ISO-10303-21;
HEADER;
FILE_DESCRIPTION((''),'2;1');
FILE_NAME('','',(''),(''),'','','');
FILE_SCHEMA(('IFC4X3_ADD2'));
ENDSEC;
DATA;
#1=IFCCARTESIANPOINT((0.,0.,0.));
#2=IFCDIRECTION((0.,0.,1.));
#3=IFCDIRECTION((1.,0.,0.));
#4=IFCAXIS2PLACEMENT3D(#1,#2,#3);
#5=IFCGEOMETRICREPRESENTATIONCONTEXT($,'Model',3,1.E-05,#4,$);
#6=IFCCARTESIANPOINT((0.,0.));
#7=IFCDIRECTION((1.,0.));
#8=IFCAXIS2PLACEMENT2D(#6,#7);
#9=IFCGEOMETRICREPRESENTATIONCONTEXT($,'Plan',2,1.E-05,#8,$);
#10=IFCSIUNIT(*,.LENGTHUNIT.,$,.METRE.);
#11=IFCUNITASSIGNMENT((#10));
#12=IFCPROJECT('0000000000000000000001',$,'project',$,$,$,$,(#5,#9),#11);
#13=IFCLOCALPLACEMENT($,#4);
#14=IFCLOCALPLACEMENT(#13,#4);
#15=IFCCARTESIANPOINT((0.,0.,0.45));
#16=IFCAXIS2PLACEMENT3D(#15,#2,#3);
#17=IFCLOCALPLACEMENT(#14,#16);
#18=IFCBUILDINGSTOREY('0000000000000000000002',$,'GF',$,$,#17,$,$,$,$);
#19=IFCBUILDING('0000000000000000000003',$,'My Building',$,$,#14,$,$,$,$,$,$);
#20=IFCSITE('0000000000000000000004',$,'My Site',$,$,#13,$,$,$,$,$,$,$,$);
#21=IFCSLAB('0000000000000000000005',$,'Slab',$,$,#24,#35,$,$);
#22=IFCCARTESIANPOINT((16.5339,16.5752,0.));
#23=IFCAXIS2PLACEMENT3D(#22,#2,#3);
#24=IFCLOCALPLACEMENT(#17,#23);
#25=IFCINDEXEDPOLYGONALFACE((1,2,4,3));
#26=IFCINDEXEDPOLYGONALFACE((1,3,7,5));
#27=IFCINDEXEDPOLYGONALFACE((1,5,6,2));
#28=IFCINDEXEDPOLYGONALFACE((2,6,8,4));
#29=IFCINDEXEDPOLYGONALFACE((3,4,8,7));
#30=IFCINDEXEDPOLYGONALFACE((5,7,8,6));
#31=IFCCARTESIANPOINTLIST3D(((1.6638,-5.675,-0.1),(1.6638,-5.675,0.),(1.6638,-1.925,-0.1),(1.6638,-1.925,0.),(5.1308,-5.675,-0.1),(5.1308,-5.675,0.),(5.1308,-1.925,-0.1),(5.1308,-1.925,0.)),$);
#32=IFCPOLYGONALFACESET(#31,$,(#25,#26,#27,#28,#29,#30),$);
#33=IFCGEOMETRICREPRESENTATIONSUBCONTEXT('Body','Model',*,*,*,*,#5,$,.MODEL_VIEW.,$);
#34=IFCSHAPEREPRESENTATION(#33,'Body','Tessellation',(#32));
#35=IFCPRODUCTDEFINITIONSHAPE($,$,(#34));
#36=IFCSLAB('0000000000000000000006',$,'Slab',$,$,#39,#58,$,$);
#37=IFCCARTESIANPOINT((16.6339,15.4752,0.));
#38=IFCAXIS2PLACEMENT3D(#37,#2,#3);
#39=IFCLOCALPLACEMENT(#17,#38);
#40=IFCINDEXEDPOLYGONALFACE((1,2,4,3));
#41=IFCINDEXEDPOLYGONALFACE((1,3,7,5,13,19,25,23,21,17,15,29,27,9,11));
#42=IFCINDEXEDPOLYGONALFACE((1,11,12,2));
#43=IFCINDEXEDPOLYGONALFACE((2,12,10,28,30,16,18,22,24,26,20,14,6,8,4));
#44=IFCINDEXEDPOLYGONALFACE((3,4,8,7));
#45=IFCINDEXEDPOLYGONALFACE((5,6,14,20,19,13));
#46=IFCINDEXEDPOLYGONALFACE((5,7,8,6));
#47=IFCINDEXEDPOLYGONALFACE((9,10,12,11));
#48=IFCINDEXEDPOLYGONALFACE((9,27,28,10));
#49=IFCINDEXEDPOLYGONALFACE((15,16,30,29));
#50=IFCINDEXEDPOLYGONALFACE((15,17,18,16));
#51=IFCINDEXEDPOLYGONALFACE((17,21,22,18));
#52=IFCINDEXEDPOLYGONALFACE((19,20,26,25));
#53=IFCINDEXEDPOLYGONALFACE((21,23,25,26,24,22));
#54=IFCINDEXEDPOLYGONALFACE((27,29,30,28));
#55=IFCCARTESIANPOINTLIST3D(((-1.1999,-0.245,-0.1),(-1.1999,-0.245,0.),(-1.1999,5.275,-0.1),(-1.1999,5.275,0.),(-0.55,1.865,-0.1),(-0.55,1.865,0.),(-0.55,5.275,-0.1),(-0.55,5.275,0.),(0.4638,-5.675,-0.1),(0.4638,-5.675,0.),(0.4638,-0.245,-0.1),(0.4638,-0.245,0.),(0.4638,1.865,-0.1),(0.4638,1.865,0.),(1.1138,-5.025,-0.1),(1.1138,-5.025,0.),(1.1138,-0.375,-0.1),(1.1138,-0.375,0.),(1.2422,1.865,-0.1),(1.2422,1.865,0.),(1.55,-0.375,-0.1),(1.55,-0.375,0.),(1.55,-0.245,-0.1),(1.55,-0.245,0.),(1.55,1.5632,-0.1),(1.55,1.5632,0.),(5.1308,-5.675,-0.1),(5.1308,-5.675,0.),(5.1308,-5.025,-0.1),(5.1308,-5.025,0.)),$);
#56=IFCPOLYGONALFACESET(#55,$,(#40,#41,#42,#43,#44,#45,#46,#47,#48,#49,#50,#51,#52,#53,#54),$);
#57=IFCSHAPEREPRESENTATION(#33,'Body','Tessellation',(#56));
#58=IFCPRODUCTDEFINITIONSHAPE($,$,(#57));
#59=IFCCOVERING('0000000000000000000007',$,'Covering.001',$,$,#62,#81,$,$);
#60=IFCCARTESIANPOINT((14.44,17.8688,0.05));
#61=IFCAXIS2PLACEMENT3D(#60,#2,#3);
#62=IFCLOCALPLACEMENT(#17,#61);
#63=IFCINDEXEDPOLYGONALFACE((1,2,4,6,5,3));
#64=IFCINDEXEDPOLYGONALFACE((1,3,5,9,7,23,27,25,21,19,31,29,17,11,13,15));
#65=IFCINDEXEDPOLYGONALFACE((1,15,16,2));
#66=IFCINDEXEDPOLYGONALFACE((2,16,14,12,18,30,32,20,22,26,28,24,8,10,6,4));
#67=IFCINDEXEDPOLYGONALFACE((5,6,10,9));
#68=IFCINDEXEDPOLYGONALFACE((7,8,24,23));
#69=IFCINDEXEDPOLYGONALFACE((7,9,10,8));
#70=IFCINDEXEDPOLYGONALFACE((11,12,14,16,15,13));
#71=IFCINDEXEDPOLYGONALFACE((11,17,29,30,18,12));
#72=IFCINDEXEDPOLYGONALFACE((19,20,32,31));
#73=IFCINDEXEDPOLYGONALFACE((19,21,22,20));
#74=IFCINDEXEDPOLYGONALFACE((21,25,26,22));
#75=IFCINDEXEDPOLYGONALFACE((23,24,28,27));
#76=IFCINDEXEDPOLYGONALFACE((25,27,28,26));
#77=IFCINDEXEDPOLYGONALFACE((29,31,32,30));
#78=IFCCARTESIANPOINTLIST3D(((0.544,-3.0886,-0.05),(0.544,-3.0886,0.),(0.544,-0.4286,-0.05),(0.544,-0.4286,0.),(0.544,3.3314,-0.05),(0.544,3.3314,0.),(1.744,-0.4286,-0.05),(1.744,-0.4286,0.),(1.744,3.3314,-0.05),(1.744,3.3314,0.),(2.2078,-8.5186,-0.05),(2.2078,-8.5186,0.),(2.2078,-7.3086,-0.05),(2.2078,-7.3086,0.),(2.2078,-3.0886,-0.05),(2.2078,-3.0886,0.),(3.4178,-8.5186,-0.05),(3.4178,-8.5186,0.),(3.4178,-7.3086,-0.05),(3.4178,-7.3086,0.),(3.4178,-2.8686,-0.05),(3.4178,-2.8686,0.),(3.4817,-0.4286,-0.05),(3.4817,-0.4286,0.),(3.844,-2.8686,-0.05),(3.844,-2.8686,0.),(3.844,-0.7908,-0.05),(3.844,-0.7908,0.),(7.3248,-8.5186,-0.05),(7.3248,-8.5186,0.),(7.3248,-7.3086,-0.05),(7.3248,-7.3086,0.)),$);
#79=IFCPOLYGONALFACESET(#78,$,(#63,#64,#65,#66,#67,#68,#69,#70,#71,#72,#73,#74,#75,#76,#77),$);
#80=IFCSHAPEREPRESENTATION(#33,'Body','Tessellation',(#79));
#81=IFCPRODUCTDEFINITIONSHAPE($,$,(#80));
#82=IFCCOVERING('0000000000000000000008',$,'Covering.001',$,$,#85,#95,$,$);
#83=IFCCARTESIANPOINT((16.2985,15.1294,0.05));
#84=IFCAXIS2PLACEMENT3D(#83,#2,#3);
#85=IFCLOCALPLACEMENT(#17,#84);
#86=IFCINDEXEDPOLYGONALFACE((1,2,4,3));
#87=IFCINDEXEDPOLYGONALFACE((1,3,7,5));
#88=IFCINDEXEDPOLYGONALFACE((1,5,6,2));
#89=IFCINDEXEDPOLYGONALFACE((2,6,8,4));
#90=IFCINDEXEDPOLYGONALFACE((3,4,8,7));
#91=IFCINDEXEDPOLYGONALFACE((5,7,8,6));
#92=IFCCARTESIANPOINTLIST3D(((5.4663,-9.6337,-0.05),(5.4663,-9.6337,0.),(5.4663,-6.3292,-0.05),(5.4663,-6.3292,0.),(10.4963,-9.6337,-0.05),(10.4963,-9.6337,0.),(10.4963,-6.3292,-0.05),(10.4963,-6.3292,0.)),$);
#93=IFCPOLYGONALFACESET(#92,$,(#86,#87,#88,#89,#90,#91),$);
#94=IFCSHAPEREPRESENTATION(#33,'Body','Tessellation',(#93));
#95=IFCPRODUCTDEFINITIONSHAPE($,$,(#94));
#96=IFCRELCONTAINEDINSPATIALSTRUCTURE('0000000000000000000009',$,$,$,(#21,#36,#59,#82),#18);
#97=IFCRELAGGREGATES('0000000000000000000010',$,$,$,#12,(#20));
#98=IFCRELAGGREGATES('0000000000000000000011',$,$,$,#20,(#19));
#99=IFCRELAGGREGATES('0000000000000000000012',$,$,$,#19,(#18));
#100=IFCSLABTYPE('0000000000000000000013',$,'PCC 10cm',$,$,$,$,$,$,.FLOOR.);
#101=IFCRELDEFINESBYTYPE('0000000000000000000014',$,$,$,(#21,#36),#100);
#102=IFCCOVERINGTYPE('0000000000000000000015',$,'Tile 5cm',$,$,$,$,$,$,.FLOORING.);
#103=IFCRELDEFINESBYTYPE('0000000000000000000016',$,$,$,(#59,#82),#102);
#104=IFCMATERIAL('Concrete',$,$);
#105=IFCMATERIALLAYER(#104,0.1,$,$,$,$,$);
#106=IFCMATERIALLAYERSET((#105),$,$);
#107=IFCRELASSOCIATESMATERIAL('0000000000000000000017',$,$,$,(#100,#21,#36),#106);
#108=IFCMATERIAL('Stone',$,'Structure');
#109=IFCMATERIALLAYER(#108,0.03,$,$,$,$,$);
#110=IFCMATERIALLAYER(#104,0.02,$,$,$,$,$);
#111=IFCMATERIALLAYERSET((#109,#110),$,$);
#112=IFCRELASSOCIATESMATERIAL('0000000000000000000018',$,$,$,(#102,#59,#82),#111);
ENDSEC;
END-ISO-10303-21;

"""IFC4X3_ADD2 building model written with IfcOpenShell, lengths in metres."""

from ifc_helpers import new_model, si_unit, frame, origin_with_axes, origin_2d_with_axis, place, context, subcontext, project, spatial, indexed_curve, outline, extrude, material, layer, layer_set, layer_usage, type_object, element, save


model = new_model("IFC4X3_ADD2")

# Units and contexts
model_context = context("Model", 3, precision=1e-05, world=origin_with_axes())
plan_context = context("Plan", 2, precision=1e-05, world=origin_2d_with_axis())
body_context_1 = subcontext(model_context, "Body", "Model", "MODEL_VIEW")
ifc_project = project(units=[si_unit("LENGTHUNIT", "METRE")], contexts=[model_context, plan_context])

# Site, building, storey
site_placement = place(None, origin_with_axes())
site = spatial("IfcSite", under=ifc_project, at=site_placement, Name="My Site")
building_placement = place(site_placement, origin_with_axes())
building = spatial("IfcBuilding", under=site, at=building_placement, Name="My Building")
storey_placement = place(building_placement, frame((0.0, 0.0, 0.45), z_axis=(0.0, 0.0, 1.0), x_axis=(1.0, 0.0, 0.0)))
storey = spatial("IfcBuildingStorey", under=building, at=storey_placement, Name="GF")

# Slabs
ifc_material_1 = material(Name="Concrete")
ifc_layer_1 = layer(ifc_material_1, 0.1)
ifc_layer_set_1 = layer_set([ifc_layer_1])
ifc_layer_usage_1 = layer_usage(ifc_layer_set_1, "AXIS3", "POSITIVE", -0.1)
slab_type = type_object("IfcSlabType", Name="PCC 10cm", PredefinedType="FLOOR", material=ifc_layer_set_1)
slab_1_placement = place(storey_placement, frame((16.5339, 16.5752, 0.0), z_axis=(0.0, 0.0, 1.0), x_axis=(1.0, 0.0, 0.0)))
element("IfcSlab", 1, at=slab_1_placement, inside=storey, type_object=slab_type, material=ifc_layer_usage_1, Name="Slab", context=body_context_1, shape_type="SweptSolid", body=[
    extrude(outline(indexed_curve([(1.6638, -1.925), (5.1308, -1.925), (5.1308, -5.675), (1.6638, -5.675), (1.6638, -1.925)])), frame((0.0, 0.0, -0.1), z_axis=(0.0, 0.0, 1.0), x_axis=(1.0, 0.0, 0.0)), (0.0, 0.0, 1.0), 0.1),
])
ifc_layer_usage_2 = layer_usage(ifc_layer_set_1, "AXIS3", "POSITIVE", -0.1)
slab_2_placement = place(storey_placement, frame((16.6339, 15.4752, 0.0), z_axis=(0.0, 0.0, 1.0), x_axis=(1.0, 0.0, 0.0)))
element("IfcSlab", 2, at=slab_2_placement, inside=storey, type_object=slab_type, material=ifc_layer_usage_2, Name="Slab", context=body_context_1, shape_type="SweptSolid", body=[
    extrude(outline(indexed_curve([(1.55, -0.375), (1.1138, -0.375), (1.1138, -5.025), (5.1308, -5.025), (5.1308, -5.675), (0.4638, -5.675), (0.4638, -0.245), (-1.1999, -0.245), (-1.1999, 5.275), (-0.55, 5.275), (-0.55, 1.865), (0.4638, 1.865), (1.2422, 1.865), (1.55, 1.5632), (1.55, -0.245), (1.55, -0.375)])), frame((0.0, 0.0, -0.1), z_axis=(0.0, 0.0, 1.0), x_axis=(1.0, 0.0, 0.0)), (0.0, 0.0, 1.0), 0.1),
])

# Coverings
ifc_material_2 = material(Name="Stone", Category="Structure")
ifc_layer_2 = layer(ifc_material_2, 0.03)
ifc_layer_3 = layer(ifc_material_1, 0.02)
ifc_layer_set_2 = layer_set([ifc_layer_2, ifc_layer_3])
ifc_layer_usage_3 = layer_usage(ifc_layer_set_2, "AXIS3", "POSITIVE", -0.05)
covering_type = type_object("IfcCoveringType", Name="Tile 5cm", PredefinedType="FLOORING", material=ifc_layer_set_2)
covering_1_placement = place(storey_placement, frame((14.44, 17.8688, 0.05), z_axis=(0.0, 0.0, 1.0), x_axis=(1.0, 0.0, 0.0)))
element("IfcCovering", 3, at=covering_1_placement, inside=storey, type_object=covering_type, material=ifc_layer_usage_3, Name="Covering.001", context=body_context_1, shape_type="SweptSolid", body=[
    extrude(outline(indexed_curve([(0.544, -0.4286), (0.544, 3.3314), (1.744, 3.3314), (1.744, -0.4286), (3.4817, -0.4286), (3.844, -0.7908), (3.844, -2.8686), (3.4178, -2.8686), (3.4178, -7.3086), (7.3248, -7.3086), (7.3248, -8.5186), (3.4178, -8.5186), (2.2078, -8.5186), (2.2078, -7.3086), (2.2078, -3.0886), (0.544, -3.0886), (0.544, -0.4286)])), frame((0.0, 0.0, -0.05), z_axis=(0.0, 0.0, 1.0), x_axis=(1.0, 0.0, 0.0)), (0.0, 0.0, 1.0), 0.05),
])
ifc_layer_usage_4 = layer_usage(ifc_layer_set_2, "AXIS3", "POSITIVE", -0.05)
covering_2_placement = place(storey_placement, frame((16.2985, 15.1294, 0.05), z_axis=(0.0, 0.0, 1.0), x_axis=(1.0, 0.0, 0.0)))
element("IfcCovering", 4, at=covering_2_placement, inside=storey, type_object=covering_type, material=ifc_layer_usage_4, Name="Covering.001", context=body_context_1, shape_type="SweptSolid", body=[
    extrude(outline(indexed_curve([(5.4663, -9.6337), (10.4963, -9.6337), (10.4963, -6.3292), (5.4663, -6.3292), (5.4663, -9.6337)])), frame((0.0, 0.0, -0.05), z_axis=(0.0, 0.0, 1.0), x_axis=(1.0, 0.0, 0.0)), (0.0, 0.0, 1.0), 0.05),
])

save(model, "model.ifc")
